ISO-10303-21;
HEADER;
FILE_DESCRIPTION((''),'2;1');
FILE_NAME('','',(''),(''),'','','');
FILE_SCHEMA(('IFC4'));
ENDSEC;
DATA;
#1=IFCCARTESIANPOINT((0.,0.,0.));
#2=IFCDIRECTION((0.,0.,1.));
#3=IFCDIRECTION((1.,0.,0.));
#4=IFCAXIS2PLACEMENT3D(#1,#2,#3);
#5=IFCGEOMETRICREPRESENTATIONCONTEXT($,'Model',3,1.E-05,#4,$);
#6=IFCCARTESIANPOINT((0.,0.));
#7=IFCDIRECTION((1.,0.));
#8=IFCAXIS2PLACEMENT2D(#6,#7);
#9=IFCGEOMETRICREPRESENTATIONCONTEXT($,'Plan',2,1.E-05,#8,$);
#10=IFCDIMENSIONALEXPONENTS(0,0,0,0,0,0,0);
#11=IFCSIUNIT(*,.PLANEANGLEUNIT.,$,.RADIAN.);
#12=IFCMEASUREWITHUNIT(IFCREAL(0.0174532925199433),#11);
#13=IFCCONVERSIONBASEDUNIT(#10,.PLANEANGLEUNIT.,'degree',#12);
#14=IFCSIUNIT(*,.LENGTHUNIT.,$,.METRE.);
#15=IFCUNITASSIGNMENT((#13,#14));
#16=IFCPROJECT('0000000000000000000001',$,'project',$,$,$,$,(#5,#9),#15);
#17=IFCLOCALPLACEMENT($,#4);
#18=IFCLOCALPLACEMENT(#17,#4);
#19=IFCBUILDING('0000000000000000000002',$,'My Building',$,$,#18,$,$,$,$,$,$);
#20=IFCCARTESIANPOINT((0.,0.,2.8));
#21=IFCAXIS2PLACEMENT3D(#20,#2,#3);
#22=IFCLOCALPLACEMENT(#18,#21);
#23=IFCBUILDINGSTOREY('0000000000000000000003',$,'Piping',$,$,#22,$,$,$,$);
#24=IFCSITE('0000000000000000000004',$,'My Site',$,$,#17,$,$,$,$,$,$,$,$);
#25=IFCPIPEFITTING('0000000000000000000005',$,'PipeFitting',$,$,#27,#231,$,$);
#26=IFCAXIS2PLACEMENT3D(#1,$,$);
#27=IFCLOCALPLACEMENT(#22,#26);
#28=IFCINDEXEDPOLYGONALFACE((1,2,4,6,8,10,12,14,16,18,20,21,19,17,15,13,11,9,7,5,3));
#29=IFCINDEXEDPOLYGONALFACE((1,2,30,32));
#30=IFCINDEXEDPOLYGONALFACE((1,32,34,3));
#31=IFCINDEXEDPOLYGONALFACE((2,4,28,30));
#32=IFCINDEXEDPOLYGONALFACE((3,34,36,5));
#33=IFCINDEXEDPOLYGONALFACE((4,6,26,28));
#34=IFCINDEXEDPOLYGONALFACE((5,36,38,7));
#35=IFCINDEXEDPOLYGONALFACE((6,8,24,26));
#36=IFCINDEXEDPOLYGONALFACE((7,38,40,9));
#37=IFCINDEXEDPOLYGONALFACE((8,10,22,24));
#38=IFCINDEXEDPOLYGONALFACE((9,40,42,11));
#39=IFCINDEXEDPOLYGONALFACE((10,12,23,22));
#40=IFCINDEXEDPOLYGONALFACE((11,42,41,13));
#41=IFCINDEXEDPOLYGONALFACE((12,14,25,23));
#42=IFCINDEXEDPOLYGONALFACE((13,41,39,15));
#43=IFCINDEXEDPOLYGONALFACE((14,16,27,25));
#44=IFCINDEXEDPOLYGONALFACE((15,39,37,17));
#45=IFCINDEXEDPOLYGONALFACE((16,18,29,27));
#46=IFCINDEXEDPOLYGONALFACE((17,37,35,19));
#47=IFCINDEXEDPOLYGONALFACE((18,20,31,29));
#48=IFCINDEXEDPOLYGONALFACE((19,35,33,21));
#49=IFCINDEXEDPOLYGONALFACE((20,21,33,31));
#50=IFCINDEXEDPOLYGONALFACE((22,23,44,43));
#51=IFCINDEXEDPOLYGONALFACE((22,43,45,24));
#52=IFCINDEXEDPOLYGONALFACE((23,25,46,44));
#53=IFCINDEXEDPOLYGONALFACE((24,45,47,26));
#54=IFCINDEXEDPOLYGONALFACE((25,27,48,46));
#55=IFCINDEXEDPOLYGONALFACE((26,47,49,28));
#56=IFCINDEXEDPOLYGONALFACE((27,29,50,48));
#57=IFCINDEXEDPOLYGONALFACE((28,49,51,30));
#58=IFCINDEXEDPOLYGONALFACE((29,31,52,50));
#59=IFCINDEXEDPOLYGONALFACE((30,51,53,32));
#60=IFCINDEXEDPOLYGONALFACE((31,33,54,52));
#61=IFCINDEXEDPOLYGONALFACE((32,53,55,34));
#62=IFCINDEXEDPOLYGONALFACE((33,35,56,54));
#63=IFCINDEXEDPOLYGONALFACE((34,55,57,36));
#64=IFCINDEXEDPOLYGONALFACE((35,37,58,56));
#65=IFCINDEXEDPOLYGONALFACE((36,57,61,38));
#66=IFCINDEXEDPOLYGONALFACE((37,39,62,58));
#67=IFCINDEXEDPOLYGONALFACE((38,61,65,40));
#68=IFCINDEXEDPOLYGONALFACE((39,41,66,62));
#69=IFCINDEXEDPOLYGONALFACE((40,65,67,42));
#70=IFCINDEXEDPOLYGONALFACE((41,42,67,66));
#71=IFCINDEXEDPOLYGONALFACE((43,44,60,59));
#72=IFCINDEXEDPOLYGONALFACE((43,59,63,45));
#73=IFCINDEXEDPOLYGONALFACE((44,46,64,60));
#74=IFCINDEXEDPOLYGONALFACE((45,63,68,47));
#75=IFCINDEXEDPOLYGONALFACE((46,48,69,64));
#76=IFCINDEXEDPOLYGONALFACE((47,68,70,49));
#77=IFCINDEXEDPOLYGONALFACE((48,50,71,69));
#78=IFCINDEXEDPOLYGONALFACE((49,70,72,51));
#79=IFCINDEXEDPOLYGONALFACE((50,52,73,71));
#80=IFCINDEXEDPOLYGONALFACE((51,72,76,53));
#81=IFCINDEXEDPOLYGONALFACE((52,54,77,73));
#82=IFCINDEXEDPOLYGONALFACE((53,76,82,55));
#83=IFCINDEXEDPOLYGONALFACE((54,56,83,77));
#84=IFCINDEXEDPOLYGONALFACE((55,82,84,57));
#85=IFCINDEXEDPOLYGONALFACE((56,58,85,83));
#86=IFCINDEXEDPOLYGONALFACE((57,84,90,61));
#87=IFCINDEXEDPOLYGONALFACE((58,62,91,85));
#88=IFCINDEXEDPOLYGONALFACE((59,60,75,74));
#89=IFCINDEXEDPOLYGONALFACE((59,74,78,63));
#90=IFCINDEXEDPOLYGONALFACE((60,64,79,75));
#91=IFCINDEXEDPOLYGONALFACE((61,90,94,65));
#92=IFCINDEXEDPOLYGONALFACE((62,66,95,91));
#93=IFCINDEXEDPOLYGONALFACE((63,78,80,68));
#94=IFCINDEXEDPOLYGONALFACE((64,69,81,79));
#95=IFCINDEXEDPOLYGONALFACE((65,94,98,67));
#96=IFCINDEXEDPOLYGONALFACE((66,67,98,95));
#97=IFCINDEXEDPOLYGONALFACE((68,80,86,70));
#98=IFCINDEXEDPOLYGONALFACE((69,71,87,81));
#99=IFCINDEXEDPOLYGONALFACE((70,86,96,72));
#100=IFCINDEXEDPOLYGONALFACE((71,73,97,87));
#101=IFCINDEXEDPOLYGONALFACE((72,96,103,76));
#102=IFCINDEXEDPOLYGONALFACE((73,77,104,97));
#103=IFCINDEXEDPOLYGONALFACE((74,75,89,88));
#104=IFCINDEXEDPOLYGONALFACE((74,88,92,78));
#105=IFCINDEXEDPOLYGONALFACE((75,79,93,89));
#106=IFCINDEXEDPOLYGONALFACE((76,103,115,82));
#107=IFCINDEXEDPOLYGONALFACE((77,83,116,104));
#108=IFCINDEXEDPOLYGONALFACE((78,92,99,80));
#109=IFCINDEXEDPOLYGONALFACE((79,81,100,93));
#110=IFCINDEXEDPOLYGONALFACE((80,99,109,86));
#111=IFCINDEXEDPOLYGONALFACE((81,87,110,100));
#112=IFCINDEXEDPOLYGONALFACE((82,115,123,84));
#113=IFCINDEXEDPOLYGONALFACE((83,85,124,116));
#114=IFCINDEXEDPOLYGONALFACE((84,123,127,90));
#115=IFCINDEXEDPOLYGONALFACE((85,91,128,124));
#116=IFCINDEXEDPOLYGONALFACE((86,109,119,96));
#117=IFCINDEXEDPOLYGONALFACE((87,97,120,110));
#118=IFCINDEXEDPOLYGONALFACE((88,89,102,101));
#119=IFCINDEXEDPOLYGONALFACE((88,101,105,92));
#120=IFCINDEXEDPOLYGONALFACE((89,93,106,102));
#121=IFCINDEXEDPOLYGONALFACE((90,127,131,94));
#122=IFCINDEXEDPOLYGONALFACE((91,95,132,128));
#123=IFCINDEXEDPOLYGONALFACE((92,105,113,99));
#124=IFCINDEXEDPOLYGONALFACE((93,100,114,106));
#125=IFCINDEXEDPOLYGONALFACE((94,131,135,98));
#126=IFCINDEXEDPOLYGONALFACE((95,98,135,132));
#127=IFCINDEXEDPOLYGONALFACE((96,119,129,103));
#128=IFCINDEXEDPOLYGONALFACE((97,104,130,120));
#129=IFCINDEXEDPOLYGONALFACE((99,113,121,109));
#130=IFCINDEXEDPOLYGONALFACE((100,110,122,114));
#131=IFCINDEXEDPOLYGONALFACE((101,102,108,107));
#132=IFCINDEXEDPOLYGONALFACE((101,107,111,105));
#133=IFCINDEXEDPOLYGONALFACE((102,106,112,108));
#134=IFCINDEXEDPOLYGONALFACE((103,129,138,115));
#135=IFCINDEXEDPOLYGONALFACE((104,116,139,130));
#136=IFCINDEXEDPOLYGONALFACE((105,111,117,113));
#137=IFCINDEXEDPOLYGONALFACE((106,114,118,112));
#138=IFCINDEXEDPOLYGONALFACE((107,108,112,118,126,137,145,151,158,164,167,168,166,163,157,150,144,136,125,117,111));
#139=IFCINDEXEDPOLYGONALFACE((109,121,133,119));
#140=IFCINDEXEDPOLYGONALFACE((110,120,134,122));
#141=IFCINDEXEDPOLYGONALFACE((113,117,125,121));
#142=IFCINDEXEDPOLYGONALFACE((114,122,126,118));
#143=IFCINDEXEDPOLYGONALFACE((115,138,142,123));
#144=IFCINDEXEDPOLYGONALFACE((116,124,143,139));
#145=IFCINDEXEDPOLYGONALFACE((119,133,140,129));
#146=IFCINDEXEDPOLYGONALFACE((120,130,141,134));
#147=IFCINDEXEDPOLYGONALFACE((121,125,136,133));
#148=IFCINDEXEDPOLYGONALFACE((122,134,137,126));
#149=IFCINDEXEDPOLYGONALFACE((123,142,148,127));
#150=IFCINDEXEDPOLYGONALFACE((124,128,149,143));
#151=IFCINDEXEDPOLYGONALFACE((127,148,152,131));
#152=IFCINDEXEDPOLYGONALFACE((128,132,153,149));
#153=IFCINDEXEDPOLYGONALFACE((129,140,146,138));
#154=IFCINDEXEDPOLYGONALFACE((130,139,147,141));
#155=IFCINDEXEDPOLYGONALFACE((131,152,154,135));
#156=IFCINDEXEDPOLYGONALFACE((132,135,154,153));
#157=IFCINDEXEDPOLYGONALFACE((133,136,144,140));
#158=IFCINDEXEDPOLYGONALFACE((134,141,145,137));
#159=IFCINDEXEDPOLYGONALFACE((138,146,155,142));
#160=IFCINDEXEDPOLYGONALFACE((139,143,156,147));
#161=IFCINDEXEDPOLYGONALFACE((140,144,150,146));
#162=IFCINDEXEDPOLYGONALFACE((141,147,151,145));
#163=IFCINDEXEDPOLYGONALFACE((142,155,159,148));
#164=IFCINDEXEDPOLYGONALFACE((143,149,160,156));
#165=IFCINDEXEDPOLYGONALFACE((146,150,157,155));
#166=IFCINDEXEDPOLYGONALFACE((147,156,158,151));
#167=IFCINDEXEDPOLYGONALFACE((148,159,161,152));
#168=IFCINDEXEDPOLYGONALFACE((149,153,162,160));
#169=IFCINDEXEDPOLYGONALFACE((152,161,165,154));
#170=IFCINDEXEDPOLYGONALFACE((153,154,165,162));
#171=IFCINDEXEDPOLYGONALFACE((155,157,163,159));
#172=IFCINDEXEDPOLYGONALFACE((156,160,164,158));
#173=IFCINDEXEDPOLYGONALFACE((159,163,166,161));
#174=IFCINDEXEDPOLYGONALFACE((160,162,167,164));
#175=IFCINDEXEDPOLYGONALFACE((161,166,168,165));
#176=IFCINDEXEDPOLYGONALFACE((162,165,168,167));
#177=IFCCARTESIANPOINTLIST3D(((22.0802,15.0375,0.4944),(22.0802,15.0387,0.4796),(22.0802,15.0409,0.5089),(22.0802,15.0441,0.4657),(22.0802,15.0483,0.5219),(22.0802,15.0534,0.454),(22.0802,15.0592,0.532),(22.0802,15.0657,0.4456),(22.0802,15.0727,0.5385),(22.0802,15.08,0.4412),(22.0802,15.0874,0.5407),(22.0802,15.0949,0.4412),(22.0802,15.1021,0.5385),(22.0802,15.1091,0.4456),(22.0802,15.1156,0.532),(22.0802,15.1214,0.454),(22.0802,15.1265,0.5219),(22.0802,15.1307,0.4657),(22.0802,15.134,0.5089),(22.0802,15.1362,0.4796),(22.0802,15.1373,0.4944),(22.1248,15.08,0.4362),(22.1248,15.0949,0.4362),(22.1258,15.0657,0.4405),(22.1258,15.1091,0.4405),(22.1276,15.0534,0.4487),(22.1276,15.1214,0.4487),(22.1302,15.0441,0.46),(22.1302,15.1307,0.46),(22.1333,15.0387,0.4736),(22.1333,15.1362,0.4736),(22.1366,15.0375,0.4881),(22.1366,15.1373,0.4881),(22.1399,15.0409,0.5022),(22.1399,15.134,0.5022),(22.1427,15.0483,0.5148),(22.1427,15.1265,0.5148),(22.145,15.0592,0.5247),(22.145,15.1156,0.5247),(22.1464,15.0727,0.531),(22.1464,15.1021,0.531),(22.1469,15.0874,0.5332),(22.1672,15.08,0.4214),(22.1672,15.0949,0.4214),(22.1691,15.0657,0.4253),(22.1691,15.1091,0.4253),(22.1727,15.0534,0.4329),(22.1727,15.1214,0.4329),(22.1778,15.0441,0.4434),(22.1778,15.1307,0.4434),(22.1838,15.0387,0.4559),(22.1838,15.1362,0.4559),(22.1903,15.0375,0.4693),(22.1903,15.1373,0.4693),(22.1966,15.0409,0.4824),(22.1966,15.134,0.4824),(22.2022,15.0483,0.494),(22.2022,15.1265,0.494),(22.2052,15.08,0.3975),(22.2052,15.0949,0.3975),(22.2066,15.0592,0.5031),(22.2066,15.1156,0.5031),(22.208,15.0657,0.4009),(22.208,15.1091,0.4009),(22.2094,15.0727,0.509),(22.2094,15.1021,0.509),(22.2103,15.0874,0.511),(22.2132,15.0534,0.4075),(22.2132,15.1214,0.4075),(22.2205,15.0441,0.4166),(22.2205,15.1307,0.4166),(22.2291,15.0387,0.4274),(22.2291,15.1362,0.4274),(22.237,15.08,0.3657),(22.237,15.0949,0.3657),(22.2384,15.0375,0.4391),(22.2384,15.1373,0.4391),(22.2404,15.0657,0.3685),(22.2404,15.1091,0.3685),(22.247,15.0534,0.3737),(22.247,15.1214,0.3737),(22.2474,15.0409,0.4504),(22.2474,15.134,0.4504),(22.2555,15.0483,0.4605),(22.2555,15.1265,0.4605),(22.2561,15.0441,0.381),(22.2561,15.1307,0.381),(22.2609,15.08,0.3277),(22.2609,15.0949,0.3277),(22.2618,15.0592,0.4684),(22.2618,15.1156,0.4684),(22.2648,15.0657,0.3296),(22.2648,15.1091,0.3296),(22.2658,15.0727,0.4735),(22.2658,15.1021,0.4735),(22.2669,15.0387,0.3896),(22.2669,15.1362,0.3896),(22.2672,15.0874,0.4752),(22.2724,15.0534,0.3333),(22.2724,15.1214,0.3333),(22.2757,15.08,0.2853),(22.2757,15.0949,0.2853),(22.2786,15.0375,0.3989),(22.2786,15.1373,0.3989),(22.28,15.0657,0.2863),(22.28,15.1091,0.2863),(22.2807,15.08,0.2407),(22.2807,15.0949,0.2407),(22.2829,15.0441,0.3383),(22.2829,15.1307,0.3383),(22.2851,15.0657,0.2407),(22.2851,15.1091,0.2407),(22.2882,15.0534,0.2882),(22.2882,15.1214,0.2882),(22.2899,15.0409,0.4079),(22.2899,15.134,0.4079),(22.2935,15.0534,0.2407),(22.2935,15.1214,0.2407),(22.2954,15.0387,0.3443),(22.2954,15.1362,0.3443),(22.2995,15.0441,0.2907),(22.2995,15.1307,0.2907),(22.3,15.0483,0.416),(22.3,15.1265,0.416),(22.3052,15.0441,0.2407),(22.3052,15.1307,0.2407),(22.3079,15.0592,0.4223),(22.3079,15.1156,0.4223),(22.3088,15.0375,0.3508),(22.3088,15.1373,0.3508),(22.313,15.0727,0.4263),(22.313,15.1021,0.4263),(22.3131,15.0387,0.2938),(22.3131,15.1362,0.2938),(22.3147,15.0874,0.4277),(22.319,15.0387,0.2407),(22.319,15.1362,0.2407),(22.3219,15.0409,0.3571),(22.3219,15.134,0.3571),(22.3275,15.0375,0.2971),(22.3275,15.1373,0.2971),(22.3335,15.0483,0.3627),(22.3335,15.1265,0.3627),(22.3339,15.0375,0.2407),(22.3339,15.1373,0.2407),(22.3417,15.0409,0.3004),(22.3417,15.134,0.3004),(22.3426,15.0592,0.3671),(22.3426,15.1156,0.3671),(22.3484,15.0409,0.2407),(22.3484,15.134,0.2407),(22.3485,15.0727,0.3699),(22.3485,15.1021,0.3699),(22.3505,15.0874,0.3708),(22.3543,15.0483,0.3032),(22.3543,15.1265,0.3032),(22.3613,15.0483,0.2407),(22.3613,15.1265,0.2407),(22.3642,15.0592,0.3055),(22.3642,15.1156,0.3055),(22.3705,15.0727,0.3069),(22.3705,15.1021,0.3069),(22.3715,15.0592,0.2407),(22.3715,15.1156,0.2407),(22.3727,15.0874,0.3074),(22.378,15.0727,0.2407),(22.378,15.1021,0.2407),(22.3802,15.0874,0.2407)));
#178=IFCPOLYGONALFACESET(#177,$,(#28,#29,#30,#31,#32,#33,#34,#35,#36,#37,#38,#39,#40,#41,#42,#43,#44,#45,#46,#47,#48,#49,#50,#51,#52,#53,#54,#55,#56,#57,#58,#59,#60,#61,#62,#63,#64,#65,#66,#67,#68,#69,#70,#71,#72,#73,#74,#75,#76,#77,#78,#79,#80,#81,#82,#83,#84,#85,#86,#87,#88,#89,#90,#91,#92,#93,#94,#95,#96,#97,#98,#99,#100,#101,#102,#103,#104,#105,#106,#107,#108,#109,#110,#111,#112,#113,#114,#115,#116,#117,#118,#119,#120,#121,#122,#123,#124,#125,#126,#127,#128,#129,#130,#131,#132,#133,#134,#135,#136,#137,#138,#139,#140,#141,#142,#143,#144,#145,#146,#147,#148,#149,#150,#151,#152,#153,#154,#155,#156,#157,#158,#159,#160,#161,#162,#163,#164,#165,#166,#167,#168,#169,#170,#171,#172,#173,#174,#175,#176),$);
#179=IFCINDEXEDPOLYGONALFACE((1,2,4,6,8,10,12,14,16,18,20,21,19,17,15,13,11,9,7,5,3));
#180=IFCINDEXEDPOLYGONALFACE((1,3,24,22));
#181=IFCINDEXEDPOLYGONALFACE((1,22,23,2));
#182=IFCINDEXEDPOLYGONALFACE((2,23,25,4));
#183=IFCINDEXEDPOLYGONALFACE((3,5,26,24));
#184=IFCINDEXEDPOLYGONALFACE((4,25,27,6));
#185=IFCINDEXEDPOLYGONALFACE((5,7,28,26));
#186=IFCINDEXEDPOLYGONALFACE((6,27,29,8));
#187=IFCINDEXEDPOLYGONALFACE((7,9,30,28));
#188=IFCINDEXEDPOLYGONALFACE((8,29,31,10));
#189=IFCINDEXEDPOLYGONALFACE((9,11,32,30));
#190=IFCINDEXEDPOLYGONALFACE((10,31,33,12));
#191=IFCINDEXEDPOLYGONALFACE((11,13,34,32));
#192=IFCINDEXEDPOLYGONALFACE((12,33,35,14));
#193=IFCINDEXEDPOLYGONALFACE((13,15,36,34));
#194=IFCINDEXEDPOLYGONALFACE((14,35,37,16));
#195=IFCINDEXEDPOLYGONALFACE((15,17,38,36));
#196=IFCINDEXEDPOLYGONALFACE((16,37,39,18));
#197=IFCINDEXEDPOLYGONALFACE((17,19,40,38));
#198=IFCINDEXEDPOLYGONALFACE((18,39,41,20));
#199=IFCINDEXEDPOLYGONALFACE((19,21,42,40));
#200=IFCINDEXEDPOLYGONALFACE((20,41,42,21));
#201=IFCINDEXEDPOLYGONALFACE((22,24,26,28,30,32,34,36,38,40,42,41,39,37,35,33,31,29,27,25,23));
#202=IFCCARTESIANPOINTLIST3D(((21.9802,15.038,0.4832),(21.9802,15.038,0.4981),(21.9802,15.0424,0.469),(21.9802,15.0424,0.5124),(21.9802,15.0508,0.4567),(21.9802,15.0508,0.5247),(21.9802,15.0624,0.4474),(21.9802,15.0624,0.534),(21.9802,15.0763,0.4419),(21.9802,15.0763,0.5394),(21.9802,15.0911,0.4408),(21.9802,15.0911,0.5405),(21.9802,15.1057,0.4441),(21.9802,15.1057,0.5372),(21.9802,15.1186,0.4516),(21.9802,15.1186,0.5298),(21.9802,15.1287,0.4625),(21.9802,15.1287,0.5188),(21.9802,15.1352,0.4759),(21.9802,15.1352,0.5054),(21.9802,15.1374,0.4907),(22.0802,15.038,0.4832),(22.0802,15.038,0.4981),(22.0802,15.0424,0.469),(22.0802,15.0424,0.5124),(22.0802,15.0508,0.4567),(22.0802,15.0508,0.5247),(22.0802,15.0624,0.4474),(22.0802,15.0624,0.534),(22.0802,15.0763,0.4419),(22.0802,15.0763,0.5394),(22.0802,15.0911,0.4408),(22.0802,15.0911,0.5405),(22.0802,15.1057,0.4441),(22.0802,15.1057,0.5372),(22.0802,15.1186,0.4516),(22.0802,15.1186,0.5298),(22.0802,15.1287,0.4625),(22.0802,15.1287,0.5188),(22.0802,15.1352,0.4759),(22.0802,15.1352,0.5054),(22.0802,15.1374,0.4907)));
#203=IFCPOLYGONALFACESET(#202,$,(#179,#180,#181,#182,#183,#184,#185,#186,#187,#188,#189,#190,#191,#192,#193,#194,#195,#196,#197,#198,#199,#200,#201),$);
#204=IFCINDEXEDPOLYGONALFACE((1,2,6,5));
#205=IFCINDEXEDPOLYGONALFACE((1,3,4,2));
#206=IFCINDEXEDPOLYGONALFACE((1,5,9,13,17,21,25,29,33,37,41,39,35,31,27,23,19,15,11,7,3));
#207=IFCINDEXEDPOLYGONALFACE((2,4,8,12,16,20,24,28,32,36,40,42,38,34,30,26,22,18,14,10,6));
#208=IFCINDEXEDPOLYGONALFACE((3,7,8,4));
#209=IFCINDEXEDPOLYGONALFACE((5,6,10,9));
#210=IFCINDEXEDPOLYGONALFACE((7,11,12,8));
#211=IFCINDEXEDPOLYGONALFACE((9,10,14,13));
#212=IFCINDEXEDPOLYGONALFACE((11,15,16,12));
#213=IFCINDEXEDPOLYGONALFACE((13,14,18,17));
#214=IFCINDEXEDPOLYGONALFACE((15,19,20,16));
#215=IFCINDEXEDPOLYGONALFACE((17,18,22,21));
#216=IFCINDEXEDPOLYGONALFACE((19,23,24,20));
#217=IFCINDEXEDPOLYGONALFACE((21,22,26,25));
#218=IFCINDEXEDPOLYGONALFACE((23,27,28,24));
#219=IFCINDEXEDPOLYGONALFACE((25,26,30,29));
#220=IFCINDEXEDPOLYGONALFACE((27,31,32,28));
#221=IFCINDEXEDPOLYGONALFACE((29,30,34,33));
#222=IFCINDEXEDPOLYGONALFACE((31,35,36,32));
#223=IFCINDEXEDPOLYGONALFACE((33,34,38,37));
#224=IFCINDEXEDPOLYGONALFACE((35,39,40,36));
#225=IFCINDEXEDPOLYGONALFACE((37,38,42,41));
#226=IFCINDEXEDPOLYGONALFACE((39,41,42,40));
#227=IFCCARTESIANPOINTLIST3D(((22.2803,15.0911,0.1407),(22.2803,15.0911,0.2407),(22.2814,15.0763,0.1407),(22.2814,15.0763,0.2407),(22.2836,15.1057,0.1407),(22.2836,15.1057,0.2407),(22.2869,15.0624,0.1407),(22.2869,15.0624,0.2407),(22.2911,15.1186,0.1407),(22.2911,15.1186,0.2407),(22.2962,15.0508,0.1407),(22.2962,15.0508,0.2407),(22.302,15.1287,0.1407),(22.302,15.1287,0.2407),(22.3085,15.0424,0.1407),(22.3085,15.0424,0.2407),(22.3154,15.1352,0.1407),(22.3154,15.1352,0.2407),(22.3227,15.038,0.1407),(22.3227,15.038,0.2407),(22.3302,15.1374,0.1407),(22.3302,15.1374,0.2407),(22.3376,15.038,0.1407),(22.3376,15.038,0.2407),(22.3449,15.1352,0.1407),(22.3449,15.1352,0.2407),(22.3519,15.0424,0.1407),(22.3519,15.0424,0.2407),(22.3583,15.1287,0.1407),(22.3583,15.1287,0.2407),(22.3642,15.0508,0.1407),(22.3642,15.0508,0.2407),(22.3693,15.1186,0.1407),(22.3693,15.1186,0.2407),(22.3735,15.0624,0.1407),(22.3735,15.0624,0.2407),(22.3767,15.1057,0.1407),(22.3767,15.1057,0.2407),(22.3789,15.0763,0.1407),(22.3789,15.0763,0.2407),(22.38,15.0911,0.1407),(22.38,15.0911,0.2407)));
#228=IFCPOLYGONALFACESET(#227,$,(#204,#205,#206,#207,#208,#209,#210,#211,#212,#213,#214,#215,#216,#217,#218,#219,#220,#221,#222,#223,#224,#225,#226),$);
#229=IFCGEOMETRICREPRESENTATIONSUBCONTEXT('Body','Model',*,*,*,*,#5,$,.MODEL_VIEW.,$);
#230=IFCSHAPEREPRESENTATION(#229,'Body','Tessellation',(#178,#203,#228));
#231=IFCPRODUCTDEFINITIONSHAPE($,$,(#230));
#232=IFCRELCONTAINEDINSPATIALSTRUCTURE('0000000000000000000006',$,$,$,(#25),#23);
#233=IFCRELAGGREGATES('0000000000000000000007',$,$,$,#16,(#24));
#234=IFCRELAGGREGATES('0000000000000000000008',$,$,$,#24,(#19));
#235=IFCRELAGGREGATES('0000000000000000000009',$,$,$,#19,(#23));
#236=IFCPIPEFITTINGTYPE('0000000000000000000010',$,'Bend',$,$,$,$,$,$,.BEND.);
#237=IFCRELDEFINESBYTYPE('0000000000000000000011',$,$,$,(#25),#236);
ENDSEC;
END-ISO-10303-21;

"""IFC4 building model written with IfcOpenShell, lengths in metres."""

from ifc_helpers import new_model, entity, si_unit, converted_unit, frame, origin_with_axes, origin_2d_with_axis, place, context, subcontext, project, spatial, circle, extrude, source, transform, mapped, type_object, type_shapes, element, save


model = new_model("IFC4")

# Units and contexts
model_context = context("Model", 3, precision=1e-05, world=origin_with_axes())
plan_context = context("Plan", 2, precision=1e-05, world=origin_2d_with_axis())
body_context = subcontext(model_context, "Body", "Model", "MODEL_VIEW")
ifc_project = project(units=[converted_unit("PLANEANGLEUNIT", "degree", entity("IfcReal", 0.0174532925199433), si_unit("PLANEANGLEUNIT", "RADIAN"), dimensions=[0, 0, 0, 0, 0, 0, 0]), si_unit("LENGTHUNIT", "METRE")], contexts=[model_context, plan_context])

# Site, building, storey
site_placement = place(None, origin_with_axes())
site = spatial("IfcSite", under=ifc_project, at=site_placement, Name="My Site")
building_placement = place(site_placement, origin_with_axes())
building = spatial("IfcBuilding", under=site, at=building_placement, Name="My Building")
storey_placement = place(building_placement, frame((0.0, 0.0, 2.8), z_axis=(0.0, 0.0, 1.0), x_axis=(1.0, 0.0, 0.0)))
storey = spatial("IfcBuildingStorey", under=building, at=storey_placement, Name="Piping")

# Pipe fitting
pipe_fitting_type_1 = type_object("IfcPipeFittingType", Name="Bend", PredefinedType="BEND")
shared_shape_1 = source(origin_with_axes(), body_context, "Body", "SolidModel", [
    entity("IfcSweptDiskSolid", entity("IfcIndexedPolyCurve", entity("IfcCartesianPointList3D", [[0.0, 0.0, 0.1], [0.0, -0.0732, 0.2768], [0.0, -0.25, 0.35]]), [entity("IfcArcIndex", [1, 2, 3])]), 0.05),
    extrude(circle(Radius=0.05), origin_with_axes(), (0.0, 0.0, 1.0), 0.1),
    extrude(circle(Radius=0.05), frame((0.0, -0.25, 0.35), z_axis=(0.0, -1.0, 0.0), x_axis=(1.0, 0.0, 0.0)), (0.0, 0.0, 1.0), 0.1),
])
type_shapes(pipe_fitting_type_1, [shared_shape_1])
for number, where, z_axis, x_axis, name in (
    (1, (21.9802, 15.0874, 0.4907), (1.0, 0.0, 0.0), (0.0, 1.0, 0.0), "PipeFitting"),
):
    element("IfcPipeFitting", number, at=place(storey_placement, frame(where, z_axis=z_axis, x_axis=x_axis)), inside=storey, type_object=pipe_fitting_type_1, Name=name, context=body_context, shape_type="MappedRepresentation", body=[
        mapped(shared_shape_1, transform((0.0, 0.0, 0.0), x_axis=(1.0, 0.0, 0.0), y_axis=(0.0, 1.0, 0.0), z_axis=(0.0, 0.0, 1.0), scale=1.0)),
    ])

save(model, "model.ifc")
